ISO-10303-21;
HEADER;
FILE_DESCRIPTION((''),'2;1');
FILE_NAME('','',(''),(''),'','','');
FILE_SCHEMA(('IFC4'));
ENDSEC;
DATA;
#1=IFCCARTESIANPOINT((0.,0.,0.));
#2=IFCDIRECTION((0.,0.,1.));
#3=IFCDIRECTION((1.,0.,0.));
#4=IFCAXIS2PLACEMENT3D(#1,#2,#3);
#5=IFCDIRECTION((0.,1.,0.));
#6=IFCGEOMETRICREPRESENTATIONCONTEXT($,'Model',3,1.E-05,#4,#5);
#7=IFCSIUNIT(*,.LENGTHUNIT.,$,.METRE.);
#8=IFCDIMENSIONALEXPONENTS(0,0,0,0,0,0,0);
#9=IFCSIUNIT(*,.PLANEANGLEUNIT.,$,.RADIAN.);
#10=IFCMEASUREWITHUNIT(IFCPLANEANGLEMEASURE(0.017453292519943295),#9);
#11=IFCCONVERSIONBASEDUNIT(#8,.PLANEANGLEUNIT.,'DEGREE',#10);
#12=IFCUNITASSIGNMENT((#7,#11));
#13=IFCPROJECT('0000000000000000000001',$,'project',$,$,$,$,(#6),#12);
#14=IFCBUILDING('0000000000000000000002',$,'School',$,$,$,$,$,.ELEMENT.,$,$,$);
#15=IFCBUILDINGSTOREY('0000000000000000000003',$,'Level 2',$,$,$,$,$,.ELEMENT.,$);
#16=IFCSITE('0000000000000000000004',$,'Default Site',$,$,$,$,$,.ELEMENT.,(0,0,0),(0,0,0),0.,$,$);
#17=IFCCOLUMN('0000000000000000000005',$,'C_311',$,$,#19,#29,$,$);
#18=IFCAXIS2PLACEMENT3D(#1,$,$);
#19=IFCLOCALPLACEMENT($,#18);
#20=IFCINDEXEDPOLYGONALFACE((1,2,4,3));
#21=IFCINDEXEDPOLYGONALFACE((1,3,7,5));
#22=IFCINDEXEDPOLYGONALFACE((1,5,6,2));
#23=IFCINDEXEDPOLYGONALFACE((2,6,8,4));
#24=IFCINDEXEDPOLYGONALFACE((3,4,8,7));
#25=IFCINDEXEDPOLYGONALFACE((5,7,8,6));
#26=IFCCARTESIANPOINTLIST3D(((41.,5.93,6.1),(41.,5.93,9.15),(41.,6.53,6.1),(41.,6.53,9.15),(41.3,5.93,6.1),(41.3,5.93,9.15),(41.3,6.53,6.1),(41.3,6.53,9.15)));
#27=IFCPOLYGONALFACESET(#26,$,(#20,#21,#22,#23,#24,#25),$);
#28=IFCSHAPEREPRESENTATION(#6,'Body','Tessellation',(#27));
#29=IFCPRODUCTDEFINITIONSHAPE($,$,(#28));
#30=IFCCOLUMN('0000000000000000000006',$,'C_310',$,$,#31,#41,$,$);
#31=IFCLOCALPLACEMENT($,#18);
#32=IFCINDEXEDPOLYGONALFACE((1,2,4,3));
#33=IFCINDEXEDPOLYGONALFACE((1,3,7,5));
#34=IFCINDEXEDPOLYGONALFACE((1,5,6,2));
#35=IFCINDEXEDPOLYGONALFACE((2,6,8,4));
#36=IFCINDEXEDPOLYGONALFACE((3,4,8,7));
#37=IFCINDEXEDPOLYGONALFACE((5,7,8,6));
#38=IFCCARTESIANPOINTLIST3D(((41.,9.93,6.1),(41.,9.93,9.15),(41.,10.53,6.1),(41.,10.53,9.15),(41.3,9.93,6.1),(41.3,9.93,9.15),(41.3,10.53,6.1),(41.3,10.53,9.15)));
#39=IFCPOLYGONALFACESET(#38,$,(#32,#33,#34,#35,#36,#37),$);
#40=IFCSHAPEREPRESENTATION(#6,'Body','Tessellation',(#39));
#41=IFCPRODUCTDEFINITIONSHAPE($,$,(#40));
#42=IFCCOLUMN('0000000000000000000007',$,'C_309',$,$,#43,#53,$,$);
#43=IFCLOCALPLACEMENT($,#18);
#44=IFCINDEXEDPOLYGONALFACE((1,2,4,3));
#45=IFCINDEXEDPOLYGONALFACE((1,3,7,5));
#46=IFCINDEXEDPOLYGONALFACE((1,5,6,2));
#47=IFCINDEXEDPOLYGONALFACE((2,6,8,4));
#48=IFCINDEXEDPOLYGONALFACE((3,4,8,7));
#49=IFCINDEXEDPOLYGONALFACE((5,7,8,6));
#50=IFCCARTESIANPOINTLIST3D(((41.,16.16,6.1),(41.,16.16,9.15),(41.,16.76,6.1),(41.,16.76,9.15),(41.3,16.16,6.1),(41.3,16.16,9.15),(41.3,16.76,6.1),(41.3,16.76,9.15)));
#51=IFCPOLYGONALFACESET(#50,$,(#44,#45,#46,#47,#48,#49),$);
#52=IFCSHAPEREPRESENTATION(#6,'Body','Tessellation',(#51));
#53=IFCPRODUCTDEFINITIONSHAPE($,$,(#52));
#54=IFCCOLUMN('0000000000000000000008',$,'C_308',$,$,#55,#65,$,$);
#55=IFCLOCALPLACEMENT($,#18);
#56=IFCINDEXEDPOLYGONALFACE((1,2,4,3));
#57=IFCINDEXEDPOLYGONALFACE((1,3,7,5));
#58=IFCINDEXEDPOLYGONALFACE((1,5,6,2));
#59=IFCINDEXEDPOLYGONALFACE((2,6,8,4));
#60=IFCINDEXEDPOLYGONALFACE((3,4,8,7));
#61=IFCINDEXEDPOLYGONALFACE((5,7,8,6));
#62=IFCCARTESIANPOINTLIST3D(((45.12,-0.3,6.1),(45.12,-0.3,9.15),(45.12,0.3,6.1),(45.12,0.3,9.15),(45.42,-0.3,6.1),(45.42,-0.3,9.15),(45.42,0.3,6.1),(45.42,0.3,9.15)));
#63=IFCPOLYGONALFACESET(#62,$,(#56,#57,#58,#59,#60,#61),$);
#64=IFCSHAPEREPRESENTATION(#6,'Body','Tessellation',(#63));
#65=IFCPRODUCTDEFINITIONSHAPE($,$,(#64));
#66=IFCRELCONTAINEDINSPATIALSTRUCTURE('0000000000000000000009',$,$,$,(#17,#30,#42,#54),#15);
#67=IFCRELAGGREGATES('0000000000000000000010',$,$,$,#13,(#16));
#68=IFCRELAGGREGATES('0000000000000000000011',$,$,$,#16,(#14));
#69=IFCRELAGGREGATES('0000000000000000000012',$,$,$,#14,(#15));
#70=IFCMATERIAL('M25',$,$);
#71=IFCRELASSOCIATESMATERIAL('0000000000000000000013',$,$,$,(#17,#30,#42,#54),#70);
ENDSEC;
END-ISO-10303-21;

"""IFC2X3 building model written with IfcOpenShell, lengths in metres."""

from ifc_helpers import new_model, entity, si_unit, converted_unit, direction, frame, frame_2d, origin_with_axes, place, context, project, spatial, rectangle, extrude, material, element, save


model = new_model("IFC2X3")

# Units and contexts
model_context = context("Model", 3, precision=1e-05, world=origin_with_axes(), true_north=direction((0.0, 1.0, 0.0)))
ifc_project = project(units=[si_unit("LENGTHUNIT", "METRE"), converted_unit("PLANEANGLEUNIT", "DEGREE", entity("IfcPlaneAngleMeasure", 0.017453292519943295), si_unit("PLANEANGLEUNIT", "RADIAN"), dimensions=[0, 0, 0, 0, 0, 0, 0])], contexts=[model_context])

# Site, building, storey
site = spatial("IfcSite", under=ifc_project, Name="Default Site", CompositionType="ELEMENT", RefLatitude=(0, 0, 0), RefLongitude=(0, 0, 0), RefElevation=0.0)
building = spatial("IfcBuilding", under=site, Name="School", CompositionType="ELEMENT")
storey = spatial("IfcBuildingStorey", under=building, Name="Level 2", CompositionType="ELEMENT")

# Columns
ifc_material = material(Name="M25")
placement = place(None, origin_with_axes())
element("IfcColumn", 1, at=placement, inside=storey, material=ifc_material, Name="C_311", context=model_context, shape_type="SweptSolid", body=[
    extrude(rectangle(XDim=0.3, YDim=0.6, at=frame_2d((0.0, 0.0), x_axis=(1.0, 0.0, 0.0))), frame((41.15, 6.23, 6.1), z_axis=(0.0, 0.0, 1.0), x_axis=(1.0, 0.0, 0.0)), (0.0, 0.0, 1.0), 3.05),
])
element("IfcColumn", 2, at=placement, inside=storey, material=ifc_material, Name="C_310", context=model_context, shape_type="SweptSolid", body=[
    extrude(rectangle(XDim=0.3, YDim=0.6, at=frame_2d((0.0, 0.0), x_axis=(1.0, 0.0, 0.0))), frame((41.15, 10.23, 6.1), z_axis=(0.0, 0.0, 1.0), x_axis=(1.0, 0.0, 0.0)), (0.0, 0.0, 1.0), 3.05),
])
element("IfcColumn", 3, at=placement, inside=storey, material=ifc_material, Name="C_309", context=model_context, shape_type="SweptSolid", body=[
    extrude(rectangle(XDim=0.3, YDim=0.6, at=frame_2d((0.0, 0.0), x_axis=(1.0, 0.0, 0.0))), frame((41.15, 16.46, 6.1), z_axis=(0.0, 0.0, 1.0), x_axis=(1.0, 0.0, 0.0)), (0.0, 0.0, 1.0), 3.05),
])
element("IfcColumn", 4, at=placement, inside=storey, material=ifc_material, Name="C_308", context=model_context, shape_type="SweptSolid", body=[
    extrude(rectangle(XDim=0.3, YDim=0.6, at=frame_2d((0.0, 0.0), x_axis=(1.0, 0.0, 0.0))), frame((45.27, 0.0, 6.1), z_axis=(0.0, 0.0, 1.0), x_axis=(1.0, 0.0, 0.0)), (0.0, 0.0, 1.0), 3.05),
])

save(model, "model.ifc")
